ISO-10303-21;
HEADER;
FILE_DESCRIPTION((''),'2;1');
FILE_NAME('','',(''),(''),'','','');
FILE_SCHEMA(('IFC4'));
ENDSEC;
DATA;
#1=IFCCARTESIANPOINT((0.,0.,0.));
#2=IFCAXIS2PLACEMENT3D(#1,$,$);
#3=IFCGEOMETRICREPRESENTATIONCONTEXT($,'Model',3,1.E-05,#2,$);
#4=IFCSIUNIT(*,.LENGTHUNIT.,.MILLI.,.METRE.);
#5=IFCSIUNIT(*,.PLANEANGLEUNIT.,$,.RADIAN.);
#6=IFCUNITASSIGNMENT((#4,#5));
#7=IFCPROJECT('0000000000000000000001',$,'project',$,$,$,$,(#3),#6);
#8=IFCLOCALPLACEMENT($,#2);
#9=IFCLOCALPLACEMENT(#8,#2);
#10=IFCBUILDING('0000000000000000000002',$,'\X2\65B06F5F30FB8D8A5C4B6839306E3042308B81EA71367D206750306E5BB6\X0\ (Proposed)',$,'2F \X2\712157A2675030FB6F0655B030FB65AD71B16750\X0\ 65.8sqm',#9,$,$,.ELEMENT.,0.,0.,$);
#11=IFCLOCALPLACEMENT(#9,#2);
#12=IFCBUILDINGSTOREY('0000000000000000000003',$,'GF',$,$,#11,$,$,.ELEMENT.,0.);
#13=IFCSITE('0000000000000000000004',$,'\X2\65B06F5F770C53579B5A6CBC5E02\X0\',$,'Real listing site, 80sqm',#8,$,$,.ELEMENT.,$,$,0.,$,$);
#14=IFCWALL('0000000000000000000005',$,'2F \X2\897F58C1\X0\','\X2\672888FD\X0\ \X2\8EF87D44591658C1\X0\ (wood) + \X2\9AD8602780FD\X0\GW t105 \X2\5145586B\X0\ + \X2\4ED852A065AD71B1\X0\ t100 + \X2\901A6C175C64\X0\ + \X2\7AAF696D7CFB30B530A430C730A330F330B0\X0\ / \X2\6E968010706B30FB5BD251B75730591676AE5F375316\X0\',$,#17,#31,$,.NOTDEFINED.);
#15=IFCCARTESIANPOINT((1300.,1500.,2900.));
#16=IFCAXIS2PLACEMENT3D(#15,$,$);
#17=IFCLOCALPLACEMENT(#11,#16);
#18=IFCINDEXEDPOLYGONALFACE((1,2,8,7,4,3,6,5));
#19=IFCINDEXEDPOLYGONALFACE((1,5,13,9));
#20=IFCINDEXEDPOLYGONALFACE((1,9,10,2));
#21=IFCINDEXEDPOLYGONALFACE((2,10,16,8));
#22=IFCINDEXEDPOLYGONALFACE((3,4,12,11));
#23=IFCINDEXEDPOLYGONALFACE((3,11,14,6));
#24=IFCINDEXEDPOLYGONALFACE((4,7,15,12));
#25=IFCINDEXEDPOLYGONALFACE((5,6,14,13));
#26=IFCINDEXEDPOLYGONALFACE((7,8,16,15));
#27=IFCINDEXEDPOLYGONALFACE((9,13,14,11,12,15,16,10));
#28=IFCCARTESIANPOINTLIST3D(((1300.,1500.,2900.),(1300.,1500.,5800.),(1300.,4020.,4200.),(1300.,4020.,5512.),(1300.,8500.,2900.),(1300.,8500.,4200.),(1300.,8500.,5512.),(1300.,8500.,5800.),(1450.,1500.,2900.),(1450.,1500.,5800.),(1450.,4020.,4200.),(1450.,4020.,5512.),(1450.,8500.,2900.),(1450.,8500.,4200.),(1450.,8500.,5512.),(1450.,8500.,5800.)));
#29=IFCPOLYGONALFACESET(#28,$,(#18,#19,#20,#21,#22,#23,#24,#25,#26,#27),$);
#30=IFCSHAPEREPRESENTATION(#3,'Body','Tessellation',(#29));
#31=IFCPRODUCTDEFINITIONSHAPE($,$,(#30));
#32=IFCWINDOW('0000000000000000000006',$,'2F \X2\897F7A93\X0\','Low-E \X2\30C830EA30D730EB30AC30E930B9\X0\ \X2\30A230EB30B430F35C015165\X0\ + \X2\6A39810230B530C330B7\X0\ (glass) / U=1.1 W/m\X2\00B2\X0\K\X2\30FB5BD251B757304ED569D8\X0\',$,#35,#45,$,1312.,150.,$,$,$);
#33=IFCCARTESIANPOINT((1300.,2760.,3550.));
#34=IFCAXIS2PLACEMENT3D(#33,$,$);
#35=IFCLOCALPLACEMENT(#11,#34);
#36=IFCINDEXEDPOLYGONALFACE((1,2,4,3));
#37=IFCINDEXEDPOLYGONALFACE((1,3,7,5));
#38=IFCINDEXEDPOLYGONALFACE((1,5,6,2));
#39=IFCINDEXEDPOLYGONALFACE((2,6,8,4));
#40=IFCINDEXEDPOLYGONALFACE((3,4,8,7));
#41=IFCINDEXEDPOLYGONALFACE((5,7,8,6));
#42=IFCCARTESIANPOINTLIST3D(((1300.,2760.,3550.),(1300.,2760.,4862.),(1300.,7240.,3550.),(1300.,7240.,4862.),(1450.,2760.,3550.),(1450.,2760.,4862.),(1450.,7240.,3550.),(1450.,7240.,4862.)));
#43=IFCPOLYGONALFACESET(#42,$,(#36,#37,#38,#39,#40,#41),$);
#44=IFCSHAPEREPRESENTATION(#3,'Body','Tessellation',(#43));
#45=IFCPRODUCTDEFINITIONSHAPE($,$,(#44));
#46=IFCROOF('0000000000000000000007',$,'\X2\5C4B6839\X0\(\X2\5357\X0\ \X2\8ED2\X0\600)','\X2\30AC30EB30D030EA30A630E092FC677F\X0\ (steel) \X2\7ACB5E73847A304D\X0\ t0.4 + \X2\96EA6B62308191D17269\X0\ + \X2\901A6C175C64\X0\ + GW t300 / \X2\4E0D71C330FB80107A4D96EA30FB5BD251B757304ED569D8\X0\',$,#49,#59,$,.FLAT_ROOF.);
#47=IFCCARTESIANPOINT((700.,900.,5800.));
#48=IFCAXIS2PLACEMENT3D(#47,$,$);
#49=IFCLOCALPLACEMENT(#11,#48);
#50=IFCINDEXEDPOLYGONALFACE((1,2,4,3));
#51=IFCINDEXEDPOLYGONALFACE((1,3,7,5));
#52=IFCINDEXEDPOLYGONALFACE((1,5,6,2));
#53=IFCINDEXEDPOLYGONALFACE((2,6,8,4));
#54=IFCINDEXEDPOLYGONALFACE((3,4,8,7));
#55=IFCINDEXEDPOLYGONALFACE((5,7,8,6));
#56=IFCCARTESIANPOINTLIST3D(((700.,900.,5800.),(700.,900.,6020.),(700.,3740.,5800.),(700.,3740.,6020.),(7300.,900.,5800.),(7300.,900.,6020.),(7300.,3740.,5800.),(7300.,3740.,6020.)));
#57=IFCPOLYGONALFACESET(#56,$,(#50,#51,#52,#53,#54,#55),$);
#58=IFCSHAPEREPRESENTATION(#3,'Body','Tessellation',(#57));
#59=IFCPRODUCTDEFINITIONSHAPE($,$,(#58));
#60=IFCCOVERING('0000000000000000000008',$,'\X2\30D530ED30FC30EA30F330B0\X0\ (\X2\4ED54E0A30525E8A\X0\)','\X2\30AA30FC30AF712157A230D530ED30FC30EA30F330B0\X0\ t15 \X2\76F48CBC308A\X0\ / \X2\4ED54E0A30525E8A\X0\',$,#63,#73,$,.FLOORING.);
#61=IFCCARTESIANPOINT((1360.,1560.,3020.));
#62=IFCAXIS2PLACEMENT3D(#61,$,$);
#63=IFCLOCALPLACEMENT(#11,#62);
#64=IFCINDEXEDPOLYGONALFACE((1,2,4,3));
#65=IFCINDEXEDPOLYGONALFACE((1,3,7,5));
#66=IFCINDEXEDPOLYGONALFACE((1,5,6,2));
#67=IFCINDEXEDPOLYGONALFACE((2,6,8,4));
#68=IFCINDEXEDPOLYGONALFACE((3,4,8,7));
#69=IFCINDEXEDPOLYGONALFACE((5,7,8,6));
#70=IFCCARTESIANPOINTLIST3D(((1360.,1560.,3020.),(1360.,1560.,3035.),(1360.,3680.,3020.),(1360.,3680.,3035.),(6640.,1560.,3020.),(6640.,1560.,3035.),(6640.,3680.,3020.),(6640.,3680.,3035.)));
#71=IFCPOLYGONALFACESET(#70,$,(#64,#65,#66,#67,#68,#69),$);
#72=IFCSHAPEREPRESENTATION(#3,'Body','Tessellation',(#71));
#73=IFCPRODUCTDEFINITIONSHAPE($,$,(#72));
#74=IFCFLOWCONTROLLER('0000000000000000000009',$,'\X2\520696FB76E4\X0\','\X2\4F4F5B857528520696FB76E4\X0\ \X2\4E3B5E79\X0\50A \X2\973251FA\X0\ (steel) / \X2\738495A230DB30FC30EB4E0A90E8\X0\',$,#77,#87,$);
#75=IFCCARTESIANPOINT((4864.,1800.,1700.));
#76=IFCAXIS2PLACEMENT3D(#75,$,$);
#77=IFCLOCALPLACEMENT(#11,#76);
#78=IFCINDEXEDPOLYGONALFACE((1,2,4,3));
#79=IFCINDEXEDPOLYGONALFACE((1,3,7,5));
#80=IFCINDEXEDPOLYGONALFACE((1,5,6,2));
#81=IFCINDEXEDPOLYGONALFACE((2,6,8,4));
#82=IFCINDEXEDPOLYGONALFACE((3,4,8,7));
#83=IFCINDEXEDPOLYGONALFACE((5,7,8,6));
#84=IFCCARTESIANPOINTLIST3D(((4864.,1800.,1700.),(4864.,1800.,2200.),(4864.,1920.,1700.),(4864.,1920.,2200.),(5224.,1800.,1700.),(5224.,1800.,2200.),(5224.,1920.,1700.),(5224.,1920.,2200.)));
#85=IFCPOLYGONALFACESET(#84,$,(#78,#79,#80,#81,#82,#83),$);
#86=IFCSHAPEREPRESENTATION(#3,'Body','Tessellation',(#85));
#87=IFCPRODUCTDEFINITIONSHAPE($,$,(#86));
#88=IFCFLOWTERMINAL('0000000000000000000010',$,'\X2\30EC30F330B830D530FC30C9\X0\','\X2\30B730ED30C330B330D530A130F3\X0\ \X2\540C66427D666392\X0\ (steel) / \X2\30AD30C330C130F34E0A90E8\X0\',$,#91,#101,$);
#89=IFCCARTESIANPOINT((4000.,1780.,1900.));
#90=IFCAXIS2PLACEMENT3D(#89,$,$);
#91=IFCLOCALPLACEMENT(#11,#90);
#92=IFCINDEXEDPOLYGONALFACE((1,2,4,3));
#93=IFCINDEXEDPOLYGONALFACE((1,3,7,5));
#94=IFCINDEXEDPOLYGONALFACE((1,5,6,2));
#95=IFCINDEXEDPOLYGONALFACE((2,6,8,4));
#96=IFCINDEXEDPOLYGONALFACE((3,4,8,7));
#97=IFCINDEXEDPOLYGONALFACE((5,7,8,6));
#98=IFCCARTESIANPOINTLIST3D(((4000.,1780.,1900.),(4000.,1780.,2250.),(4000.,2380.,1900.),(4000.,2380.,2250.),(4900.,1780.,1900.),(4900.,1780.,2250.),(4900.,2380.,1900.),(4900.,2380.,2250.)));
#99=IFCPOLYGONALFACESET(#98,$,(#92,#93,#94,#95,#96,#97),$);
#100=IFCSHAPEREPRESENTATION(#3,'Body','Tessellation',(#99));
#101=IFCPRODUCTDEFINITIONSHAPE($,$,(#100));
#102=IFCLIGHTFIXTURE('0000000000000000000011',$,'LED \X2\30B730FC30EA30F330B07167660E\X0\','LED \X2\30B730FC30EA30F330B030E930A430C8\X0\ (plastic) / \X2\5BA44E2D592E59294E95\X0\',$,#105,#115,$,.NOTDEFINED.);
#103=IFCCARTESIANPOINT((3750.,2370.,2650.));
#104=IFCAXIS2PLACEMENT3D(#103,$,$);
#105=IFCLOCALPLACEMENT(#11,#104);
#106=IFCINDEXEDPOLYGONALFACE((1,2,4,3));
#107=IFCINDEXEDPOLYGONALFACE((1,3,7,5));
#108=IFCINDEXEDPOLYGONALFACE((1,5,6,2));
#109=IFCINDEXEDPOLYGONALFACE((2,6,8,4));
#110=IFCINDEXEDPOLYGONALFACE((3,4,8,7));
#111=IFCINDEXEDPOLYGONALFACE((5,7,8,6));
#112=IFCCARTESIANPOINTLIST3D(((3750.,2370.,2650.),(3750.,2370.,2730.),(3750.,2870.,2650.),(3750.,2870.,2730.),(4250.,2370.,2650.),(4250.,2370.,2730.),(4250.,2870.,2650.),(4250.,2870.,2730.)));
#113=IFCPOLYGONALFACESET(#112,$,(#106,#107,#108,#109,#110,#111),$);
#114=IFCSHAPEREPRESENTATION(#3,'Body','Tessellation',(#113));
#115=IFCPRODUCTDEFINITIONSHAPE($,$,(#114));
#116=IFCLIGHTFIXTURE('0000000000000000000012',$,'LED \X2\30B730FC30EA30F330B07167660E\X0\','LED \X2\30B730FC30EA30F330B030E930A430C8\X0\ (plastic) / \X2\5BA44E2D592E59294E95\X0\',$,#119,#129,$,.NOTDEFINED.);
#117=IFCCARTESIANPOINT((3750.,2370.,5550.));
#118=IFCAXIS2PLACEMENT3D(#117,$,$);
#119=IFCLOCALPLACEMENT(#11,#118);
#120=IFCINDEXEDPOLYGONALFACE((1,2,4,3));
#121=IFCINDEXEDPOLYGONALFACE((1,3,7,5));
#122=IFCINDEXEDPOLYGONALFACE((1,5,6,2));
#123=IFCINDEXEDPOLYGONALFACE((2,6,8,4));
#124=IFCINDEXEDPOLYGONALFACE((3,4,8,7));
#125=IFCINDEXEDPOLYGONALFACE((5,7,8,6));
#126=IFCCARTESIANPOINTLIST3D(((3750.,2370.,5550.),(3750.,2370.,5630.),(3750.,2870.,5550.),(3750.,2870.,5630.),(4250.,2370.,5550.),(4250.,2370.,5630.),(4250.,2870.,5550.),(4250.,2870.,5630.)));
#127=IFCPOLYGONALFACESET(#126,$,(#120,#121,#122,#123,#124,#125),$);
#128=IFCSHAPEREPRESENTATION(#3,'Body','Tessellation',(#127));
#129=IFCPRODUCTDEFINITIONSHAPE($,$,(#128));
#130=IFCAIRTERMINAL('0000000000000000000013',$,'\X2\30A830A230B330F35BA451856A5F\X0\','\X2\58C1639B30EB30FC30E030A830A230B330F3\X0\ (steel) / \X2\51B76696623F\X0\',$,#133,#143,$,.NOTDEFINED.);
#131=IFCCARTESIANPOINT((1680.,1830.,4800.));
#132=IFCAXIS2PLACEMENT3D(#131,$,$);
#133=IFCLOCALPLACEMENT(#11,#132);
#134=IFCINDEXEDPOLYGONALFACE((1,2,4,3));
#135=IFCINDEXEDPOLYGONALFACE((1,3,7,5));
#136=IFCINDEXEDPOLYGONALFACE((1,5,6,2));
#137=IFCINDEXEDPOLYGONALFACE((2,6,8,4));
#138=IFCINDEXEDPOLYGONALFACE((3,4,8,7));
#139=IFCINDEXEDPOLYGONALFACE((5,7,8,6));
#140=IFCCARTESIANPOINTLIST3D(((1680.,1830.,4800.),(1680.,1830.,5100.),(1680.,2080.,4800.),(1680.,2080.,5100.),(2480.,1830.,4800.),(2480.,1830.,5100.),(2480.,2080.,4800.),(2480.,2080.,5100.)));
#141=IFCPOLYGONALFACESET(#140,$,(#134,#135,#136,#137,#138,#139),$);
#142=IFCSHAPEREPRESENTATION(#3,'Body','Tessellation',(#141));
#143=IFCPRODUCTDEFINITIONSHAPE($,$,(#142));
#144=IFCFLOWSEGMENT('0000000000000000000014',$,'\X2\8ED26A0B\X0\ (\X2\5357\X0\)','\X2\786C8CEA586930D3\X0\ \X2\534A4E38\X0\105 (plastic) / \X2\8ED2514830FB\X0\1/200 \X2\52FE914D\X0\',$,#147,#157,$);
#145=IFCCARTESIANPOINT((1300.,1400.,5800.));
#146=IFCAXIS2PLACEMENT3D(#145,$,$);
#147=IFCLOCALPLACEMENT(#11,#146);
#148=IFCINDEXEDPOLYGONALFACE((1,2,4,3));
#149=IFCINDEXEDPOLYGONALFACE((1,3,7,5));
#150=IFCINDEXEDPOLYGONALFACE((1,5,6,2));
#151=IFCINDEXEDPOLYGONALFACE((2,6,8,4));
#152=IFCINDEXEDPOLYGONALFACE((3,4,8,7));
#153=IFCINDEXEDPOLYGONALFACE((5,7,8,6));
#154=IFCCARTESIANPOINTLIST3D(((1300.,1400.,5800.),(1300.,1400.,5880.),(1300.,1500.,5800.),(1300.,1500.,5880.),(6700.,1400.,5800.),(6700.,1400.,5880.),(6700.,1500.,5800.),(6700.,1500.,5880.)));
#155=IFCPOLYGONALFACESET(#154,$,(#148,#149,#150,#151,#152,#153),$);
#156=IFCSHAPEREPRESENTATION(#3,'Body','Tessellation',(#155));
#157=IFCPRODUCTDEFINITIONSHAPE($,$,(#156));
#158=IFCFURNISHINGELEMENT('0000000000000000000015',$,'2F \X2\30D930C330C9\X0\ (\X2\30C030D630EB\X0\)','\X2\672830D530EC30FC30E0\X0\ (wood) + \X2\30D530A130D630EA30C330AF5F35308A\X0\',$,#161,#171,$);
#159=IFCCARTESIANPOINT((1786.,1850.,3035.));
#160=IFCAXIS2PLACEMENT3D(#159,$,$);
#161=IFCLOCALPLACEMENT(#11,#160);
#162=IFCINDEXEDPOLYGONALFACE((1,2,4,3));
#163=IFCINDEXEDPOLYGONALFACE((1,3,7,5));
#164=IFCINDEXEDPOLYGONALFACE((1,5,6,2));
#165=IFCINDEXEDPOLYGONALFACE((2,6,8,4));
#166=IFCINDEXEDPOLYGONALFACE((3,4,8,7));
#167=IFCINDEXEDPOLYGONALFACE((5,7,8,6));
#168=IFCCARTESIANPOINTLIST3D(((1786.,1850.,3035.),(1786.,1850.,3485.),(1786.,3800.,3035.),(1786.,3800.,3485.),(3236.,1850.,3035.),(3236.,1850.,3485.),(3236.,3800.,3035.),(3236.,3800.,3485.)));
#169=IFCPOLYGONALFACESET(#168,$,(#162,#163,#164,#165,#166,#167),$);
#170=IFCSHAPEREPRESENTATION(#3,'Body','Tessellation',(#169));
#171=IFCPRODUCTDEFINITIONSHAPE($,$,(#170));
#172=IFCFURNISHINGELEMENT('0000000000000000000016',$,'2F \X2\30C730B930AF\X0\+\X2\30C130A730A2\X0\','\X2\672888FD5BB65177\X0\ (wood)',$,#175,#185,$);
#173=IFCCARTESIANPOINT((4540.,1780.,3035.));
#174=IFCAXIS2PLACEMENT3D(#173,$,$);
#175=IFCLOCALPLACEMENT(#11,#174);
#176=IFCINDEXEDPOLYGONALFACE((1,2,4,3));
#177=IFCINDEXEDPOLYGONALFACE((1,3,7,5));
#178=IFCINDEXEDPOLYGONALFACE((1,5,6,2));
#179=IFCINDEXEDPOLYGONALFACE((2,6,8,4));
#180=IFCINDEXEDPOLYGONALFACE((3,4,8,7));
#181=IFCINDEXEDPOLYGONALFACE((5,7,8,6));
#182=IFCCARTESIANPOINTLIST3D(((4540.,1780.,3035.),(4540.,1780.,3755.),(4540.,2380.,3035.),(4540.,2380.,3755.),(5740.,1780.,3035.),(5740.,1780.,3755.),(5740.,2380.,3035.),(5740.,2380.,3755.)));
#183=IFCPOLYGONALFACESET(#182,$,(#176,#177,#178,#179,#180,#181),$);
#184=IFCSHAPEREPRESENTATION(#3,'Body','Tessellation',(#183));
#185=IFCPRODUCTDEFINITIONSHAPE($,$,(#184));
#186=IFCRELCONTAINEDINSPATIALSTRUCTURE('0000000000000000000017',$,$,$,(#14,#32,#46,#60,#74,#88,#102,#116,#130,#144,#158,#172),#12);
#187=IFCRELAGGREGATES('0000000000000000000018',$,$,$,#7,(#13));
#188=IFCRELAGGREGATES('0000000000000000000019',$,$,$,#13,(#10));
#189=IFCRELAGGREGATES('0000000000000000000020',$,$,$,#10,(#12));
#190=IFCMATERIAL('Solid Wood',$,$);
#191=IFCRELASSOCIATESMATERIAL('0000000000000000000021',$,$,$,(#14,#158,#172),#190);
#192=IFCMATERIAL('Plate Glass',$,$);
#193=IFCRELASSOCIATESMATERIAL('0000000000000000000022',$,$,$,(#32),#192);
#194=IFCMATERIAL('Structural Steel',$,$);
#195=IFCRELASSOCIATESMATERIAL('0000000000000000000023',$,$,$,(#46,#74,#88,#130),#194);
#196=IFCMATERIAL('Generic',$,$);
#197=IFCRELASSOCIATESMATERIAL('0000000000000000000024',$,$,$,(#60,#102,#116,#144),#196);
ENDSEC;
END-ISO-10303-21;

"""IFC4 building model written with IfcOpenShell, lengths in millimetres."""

from ifc_helpers import new_model, si_unit, frame, frame_2d, origin, place, context, project, spatial, rectangle, extrude, material, element, fill, save


model = new_model("IFC4")

# Units and contexts
model_context = context("Model", 3, precision=1e-05, world=origin())
ifc_project = project(units=[si_unit("LENGTHUNIT", "METRE", prefix="MILLI"), si_unit("PLANEANGLEUNIT", "RADIAN")], contexts=[model_context])

# Site, building, storey
site_placement = place(None, origin())
site = spatial("IfcSite", under=ifc_project, at=site_placement, Name="新潟県南魚沼市", ObjectType="Real listing site, 80sqm", CompositionType="ELEMENT", RefElevation=0.0)
building_placement = place(site_placement, origin())
building = spatial("IfcBuilding", under=site, at=building_placement, Name="新潟・越屋根のある自然素材の家 (Proposed)", ObjectType="2F 無垢材・漆喰・断熱材 65.8sqm", CompositionType="ELEMENT", ElevationOfRefHeight=0.0, ElevationOfTerrain=0.0)
storey_placement = place(building_placement, origin())
storey = spatial("IfcBuildingStorey", under=building, at=storey_placement, Name="GF", CompositionType="ELEMENT", Elevation=0.0)

# Shared definitions
ifc_material_1 = material(Name="Solid Wood")

# Wall, opening, window
ifc_material_2 = material(Name="Plate Glass")
wall_1_placement = place(storey_placement, frame((1300.0, 1500.0, 2900.0)))
wall_1 = element("IfcWall", 1, at=wall_1_placement, inside=storey, material=ifc_material_1, Name="2F 西壁", Description="木製 軸組外壁 (wood) + 高性能GW t105 充填 + 付加断熱 t100 + 通気層 + 窯業系サイディング / 準耐火・寒冷地外皮強化", PredefinedType="NOTDEFINED", context=model_context, shape_type="SweptSolid", body=[
    extrude(rectangle(XDim=150.0, YDim=7000.0, at=frame_2d((75.0, 3500.0))), frame((1300.0, 1500.0, 2900.0)), (0.0, 0.0, 1.0), 2900.0),
])
opening_1_placement = place(storey_placement, frame((1300.0, 2760.0, 3550.0)))
opening_1 = element("IfcOpeningElement", 2, at=opening_1_placement, cuts=wall_1, PredefinedType="NOTDEFINED", context=model_context, shape_type="SweptSolid", body=[
    extrude(rectangle(XDim=150.0, YDim=4480.0, at=frame_2d((75.0, 2240.0))), frame((1300.0, 2760.0, 3550.0)), (0.0, 0.0, 1.0), 1312.0),
])
window_1_placement = place(storey_placement, frame((1300.0, 2760.0, 3550.0)))
window_1 = element("IfcWindow", 3, at=window_1_placement, inside=storey, material=ifc_material_2, Name="2F 西窓", Description="Low-E トリプルガラス アルゴン封入 + 樹脂サッシ (glass) / U=1.1 W/m²K・寒冷地仕様", OverallHeight=1312.0, OverallWidth=150.0, context=model_context, shape_type="SweptSolid", body=[
    extrude(rectangle(XDim=150.0, YDim=4480.0, at=frame_2d((75.0, 2240.0))), frame((1300.0, 2760.0, 3550.0)), (0.0, 0.0, 1.0), 1312.0),
])
fill(opening_1, window_1)

# Roof
ifc_material_3 = material(Name="Structural Steel")
for number, where, name in (
    (4, (700.0, 900.0, 5800.0), "屋根(南 軒600)"),
):
    element("IfcRoof", number, at=place(storey_placement, frame(where)), inside=storey, material=ifc_material_3, Name=name, Description="ガルバリウム鋼板 (steel) 立平葺き t0.4 + 雪止め金物 + 通気層 + GW t300 / 不燃・耐積雪・寒冷地仕様", PredefinedType="FLAT_ROOF", context=model_context, shape_type="SweptSolid", body=[
        extrude(rectangle(XDim=6600.0, YDim=2840.0, at=frame_2d((3300.0, 1420.0))), frame((700.0, 900.0, 5800.0)), (0.0, 0.0, 1.0), 220.0),
    ])

# Covering
ifc_material_4 = material(Name="Generic")
covering_placement = place(storey_placement, frame((1360.0, 1560.0, 3020.0)))
element("IfcCovering", 5, at=covering_placement, inside=storey, material=ifc_material_4, Name="フローリング (仕上げ床)", Description="オーク無垢フローリング t15 直貼り / 仕上げ床", PredefinedType="FLOORING", context=model_context, shape_type="SweptSolid", body=[
    extrude(rectangle(XDim=5280.0, YDim=2120.0, at=frame_2d((2640.0, 1060.0))), frame((1360.0, 1560.0, 3020.0)), (0.0, 0.0, 1.0), 15.0),
])

# Flow controller
flow_controller_placement = place(storey_placement, frame((4864.0, 1800.0, 1700.0)))
element("IfcFlowController", 6, at=flow_controller_placement, inside=storey, material=ifc_material_3, Name="分電盤", Description="住宅用分電盤 主幹50A 露出 (steel) / 玄関ホール上部", context=model_context, shape_type="SweptSolid", body=[
    extrude(rectangle(XDim=360.0, YDim=120.0, at=frame_2d((180.0, 60.0))), frame((4864.0, 1800.0, 1700.0)), (0.0, 0.0, 1.0), 500.0),
])

# Flow terminal
flow_terminal_placement = place(storey_placement, frame((4000.0, 1780.0, 1900.0)))
element("IfcFlowTerminal", 7, at=flow_terminal_placement, inside=storey, material=ifc_material_3, Name="レンジフード", Description="シロッコファン 同時給排 (steel) / キッチン上部", context=model_context, shape_type="SweptSolid", body=[
    extrude(rectangle(XDim=900.0, YDim=600.0, at=frame_2d((450.0, 300.0))), frame((4000.0, 1780.0, 1900.0)), (0.0, 0.0, 1.0), 350.0),
])

# Light fixtures
light_fixture_1_placement = place(storey_placement, frame((3750.0, 2370.0, 2650.0)))
element("IfcLightFixture", 8, at=light_fixture_1_placement, inside=storey, material=ifc_material_4, Name="LED シーリング照明", Description="LED シーリングライト (plastic) / 室中央天井", PredefinedType="NOTDEFINED", context=model_context, shape_type="SweptSolid", body=[
    extrude(rectangle(XDim=500.0, YDim=500.0, at=frame_2d((250.0, 250.0))), frame((3750.0, 2370.0, 2650.0)), (0.0, 0.0, 1.0), 80.0),
])
light_fixture_2_placement = place(storey_placement, frame((3750.0, 2370.0, 5550.0)))
element("IfcLightFixture", 9, at=light_fixture_2_placement, inside=storey, material=ifc_material_4, Name="LED シーリング照明", Description="LED シーリングライト (plastic) / 室中央天井", PredefinedType="NOTDEFINED", context=model_context, shape_type="SweptSolid", body=[
    extrude(rectangle(XDim=500.0, YDim=500.0, at=frame_2d((250.0, 250.0))), frame((3750.0, 2370.0, 5550.0)), (0.0, 0.0, 1.0), 80.0),
])

# Air terminal
air_terminal_placement = place(storey_placement, frame((1680.0, 1830.0, 4800.0)))
element("IfcAirTerminal", 10, at=air_terminal_placement, inside=storey, material=ifc_material_3, Name="エアコン室内機", Description="壁掛ルームエアコン (steel) / 冷暖房", PredefinedType="NOTDEFINED", context=model_context, shape_type="SweptSolid", body=[
    extrude(rectangle(XDim=800.0, YDim=250.0, at=frame_2d((400.0, 125.0))), frame((1680.0, 1830.0, 4800.0)), (0.0, 0.0, 1.0), 300.0),
])

# Flow segment
flow_segment_placement = place(storey_placement, frame((1300.0, 1400.0, 5800.0)))
element("IfcFlowSegment", 11, at=flow_segment_placement, inside=storey, material=ifc_material_4, Name="軒樋 (南)", Description="硬質塩ビ 半丸105 (plastic) / 軒先・1/200 勾配", context=model_context, shape_type="SweptSolid", body=[
    extrude(rectangle(XDim=5400.0, YDim=100.0, at=frame_2d((2700.0, 50.0))), frame((1300.0, 1400.0, 5800.0)), (0.0, 0.0, 1.0), 80.0),
])

# Furnishing elements
furnishing_1_placement = place(storey_placement, frame((1786.0, 1850.0, 3035.0)))
element("IfcFurnishingElement", 12, at=furnishing_1_placement, inside=storey, material=ifc_material_1, Name="2F ベッド (ダブル)", Description="木フレーム (wood) + ファブリック張り", context=model_context, shape_type="SweptSolid", body=[
    extrude(rectangle(XDim=1450.0, YDim=1950.0, at=frame_2d((725.0, 975.0))), frame((1786.0, 1850.0, 3035.0)), (0.0, 0.0, 1.0), 450.0),
])
furnishing_2_placement = place(storey_placement, frame((4540.0, 1780.0, 3035.0)))
element("IfcFurnishingElement", 13, at=furnishing_2_placement, inside=storey, material=ifc_material_1, Name="2F デスク+チェア", Description="木製家具 (wood)", context=model_context, shape_type="SweptSolid", body=[
    extrude(rectangle(XDim=1200.0, YDim=600.0, at=frame_2d((600.0, 300.0))), frame((4540.0, 1780.0, 3035.0)), (0.0, 0.0, 1.0), 720.0),
])

save(model, "model.ifc")
